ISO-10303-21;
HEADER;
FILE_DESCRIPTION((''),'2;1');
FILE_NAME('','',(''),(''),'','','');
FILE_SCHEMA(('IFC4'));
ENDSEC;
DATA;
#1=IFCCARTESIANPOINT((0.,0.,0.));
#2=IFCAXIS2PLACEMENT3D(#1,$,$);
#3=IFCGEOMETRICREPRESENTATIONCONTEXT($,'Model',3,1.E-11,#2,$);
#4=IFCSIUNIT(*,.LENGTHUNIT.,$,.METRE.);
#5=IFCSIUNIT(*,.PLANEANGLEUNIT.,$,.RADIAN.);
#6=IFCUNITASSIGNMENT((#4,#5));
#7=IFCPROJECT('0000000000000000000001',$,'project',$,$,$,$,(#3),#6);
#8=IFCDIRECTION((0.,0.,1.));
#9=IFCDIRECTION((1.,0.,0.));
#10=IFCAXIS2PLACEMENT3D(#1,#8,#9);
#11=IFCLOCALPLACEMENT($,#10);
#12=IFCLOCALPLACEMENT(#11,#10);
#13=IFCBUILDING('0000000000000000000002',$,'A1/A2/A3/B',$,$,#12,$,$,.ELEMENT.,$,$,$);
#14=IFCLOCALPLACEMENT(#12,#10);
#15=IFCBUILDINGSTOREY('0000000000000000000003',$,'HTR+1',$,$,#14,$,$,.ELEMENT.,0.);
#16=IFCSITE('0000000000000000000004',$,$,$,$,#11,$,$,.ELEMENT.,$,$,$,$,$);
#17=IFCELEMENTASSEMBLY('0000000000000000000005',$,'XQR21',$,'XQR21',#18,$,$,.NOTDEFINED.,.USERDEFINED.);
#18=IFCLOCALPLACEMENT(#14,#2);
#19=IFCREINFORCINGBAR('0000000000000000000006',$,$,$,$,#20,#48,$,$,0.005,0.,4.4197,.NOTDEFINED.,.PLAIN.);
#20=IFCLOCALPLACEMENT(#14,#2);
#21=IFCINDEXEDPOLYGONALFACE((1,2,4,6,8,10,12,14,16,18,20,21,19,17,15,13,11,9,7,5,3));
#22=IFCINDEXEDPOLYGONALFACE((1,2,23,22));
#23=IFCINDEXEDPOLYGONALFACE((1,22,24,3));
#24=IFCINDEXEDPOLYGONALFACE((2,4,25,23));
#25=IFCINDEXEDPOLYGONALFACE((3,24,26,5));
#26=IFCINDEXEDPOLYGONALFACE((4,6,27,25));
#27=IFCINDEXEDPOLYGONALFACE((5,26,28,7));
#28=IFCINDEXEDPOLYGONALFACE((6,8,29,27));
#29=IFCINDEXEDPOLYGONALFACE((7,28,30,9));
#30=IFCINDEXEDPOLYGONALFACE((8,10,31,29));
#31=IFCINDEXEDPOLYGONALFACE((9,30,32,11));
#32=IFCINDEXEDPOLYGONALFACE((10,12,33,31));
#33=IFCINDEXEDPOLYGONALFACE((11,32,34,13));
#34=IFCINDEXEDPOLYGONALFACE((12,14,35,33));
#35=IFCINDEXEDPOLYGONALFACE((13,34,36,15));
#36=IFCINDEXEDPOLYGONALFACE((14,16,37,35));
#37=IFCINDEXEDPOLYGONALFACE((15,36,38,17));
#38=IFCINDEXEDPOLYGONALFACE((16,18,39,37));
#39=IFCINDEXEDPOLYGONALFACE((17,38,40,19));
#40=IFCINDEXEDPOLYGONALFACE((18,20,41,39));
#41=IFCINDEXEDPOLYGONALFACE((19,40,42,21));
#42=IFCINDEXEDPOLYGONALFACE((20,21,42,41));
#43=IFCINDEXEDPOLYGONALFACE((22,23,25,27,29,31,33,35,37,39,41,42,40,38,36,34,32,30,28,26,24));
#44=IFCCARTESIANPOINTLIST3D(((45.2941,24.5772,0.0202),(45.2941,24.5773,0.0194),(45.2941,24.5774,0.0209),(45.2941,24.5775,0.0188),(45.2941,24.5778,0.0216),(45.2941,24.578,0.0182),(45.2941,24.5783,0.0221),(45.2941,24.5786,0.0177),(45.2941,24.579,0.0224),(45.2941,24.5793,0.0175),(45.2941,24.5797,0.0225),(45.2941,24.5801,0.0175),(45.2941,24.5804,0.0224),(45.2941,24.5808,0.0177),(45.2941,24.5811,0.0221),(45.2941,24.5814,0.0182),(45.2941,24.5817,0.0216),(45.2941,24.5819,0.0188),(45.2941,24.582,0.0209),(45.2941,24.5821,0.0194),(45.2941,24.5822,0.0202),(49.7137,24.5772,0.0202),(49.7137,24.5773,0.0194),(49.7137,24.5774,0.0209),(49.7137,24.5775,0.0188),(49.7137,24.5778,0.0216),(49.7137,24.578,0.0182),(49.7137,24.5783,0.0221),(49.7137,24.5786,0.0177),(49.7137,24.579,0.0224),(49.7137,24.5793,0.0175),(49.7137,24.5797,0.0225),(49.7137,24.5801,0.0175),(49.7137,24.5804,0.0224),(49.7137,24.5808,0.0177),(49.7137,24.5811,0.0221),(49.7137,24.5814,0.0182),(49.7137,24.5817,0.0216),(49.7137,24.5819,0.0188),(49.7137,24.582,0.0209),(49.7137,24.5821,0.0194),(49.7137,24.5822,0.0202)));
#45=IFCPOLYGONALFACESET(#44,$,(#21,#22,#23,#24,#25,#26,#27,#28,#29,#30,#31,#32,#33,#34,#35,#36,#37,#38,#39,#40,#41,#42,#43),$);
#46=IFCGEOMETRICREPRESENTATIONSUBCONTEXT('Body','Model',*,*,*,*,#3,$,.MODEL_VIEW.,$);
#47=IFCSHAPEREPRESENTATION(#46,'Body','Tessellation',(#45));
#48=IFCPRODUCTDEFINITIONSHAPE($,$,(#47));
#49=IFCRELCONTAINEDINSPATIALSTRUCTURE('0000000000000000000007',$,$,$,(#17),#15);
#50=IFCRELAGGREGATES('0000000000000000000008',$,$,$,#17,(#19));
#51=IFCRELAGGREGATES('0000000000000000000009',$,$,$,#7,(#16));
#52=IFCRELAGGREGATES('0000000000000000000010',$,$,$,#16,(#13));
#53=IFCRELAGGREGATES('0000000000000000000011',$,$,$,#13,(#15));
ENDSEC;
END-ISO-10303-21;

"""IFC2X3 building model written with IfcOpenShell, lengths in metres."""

from ifc_helpers import new_model, entity, si_unit, origin, origin_with_axes, place, context, subcontext, project, spatial, shape, element, aggregate, save


model = new_model("IFC2X3")

# Units and contexts
model_context = context("Model", 3, precision=1e-11, world=origin())
body_context = subcontext(model_context, "Body", "Model", "MODEL_VIEW")
ifc_project = project(units=[si_unit("LENGTHUNIT", "METRE"), si_unit("PLANEANGLEUNIT", "RADIAN")], contexts=[model_context])

# Site, building, storey
site_placement = place(None, origin_with_axes())
site = spatial("IfcSite", under=ifc_project, at=site_placement, CompositionType="ELEMENT")
building_placement = place(site_placement, origin_with_axes())
building = spatial("IfcBuilding", under=site, at=building_placement, Name="A1/A2/A3/B", CompositionType="ELEMENT")
storey_placement = place(building_placement, origin_with_axes())
storey = spatial("IfcBuildingStorey", under=building, at=storey_placement, Name="HTR+1", CompositionType="ELEMENT", Elevation=0.0)

# Element assembly, reinforcing bar
assembly_1_placement = place(storey_placement, origin_with_axes())
assembly_1 = element("IfcElementAssembly", 1, at=assembly_1_placement, inside=storey, Name="XQR21", ObjectType="XQR21", AssemblyPlace="NOTDEFINED", PredefinedType="USERDEFINED")
reinforcing_bar_1_placement = place(assembly_1_placement, origin_with_axes())
reinforcing_bar_1 = element("IfcReinforcingBar", 2, at=reinforcing_bar_1_placement, BarLength=4.4197, BarRole="NOTDEFINED", BarSurface="PLAIN", CrossSectionArea=0.0, NominalDiameter=0.005, shapes=[
    shape(body_context, "Body", "AdvancedSweptSolid", [entity("IfcSweptDiskSolid", entity("IfcPolyline", [entity("IfcCartesianPoint", [45.2941, 24.5797, 0.02]), entity("IfcCartesianPoint", [49.7137, 24.5797, 0.02])]), 0.0025, None, 0.0, 4.4197)]),
    shape(body_context, "Body", "AdvancedSweptSolid", [entity("IfcSweptDiskSolid", entity("IfcPolyline", [entity("IfcCartesianPoint", [45.2941, 24.5797, 0.02]), entity("IfcCartesianPoint", [49.7137, 24.5797, 0.02])]), 0.0025, None, 0.0, 4.4197)]),
])
aggregate(assembly_1, [reinforcing_bar_1])

save(model, "model.ifc")
